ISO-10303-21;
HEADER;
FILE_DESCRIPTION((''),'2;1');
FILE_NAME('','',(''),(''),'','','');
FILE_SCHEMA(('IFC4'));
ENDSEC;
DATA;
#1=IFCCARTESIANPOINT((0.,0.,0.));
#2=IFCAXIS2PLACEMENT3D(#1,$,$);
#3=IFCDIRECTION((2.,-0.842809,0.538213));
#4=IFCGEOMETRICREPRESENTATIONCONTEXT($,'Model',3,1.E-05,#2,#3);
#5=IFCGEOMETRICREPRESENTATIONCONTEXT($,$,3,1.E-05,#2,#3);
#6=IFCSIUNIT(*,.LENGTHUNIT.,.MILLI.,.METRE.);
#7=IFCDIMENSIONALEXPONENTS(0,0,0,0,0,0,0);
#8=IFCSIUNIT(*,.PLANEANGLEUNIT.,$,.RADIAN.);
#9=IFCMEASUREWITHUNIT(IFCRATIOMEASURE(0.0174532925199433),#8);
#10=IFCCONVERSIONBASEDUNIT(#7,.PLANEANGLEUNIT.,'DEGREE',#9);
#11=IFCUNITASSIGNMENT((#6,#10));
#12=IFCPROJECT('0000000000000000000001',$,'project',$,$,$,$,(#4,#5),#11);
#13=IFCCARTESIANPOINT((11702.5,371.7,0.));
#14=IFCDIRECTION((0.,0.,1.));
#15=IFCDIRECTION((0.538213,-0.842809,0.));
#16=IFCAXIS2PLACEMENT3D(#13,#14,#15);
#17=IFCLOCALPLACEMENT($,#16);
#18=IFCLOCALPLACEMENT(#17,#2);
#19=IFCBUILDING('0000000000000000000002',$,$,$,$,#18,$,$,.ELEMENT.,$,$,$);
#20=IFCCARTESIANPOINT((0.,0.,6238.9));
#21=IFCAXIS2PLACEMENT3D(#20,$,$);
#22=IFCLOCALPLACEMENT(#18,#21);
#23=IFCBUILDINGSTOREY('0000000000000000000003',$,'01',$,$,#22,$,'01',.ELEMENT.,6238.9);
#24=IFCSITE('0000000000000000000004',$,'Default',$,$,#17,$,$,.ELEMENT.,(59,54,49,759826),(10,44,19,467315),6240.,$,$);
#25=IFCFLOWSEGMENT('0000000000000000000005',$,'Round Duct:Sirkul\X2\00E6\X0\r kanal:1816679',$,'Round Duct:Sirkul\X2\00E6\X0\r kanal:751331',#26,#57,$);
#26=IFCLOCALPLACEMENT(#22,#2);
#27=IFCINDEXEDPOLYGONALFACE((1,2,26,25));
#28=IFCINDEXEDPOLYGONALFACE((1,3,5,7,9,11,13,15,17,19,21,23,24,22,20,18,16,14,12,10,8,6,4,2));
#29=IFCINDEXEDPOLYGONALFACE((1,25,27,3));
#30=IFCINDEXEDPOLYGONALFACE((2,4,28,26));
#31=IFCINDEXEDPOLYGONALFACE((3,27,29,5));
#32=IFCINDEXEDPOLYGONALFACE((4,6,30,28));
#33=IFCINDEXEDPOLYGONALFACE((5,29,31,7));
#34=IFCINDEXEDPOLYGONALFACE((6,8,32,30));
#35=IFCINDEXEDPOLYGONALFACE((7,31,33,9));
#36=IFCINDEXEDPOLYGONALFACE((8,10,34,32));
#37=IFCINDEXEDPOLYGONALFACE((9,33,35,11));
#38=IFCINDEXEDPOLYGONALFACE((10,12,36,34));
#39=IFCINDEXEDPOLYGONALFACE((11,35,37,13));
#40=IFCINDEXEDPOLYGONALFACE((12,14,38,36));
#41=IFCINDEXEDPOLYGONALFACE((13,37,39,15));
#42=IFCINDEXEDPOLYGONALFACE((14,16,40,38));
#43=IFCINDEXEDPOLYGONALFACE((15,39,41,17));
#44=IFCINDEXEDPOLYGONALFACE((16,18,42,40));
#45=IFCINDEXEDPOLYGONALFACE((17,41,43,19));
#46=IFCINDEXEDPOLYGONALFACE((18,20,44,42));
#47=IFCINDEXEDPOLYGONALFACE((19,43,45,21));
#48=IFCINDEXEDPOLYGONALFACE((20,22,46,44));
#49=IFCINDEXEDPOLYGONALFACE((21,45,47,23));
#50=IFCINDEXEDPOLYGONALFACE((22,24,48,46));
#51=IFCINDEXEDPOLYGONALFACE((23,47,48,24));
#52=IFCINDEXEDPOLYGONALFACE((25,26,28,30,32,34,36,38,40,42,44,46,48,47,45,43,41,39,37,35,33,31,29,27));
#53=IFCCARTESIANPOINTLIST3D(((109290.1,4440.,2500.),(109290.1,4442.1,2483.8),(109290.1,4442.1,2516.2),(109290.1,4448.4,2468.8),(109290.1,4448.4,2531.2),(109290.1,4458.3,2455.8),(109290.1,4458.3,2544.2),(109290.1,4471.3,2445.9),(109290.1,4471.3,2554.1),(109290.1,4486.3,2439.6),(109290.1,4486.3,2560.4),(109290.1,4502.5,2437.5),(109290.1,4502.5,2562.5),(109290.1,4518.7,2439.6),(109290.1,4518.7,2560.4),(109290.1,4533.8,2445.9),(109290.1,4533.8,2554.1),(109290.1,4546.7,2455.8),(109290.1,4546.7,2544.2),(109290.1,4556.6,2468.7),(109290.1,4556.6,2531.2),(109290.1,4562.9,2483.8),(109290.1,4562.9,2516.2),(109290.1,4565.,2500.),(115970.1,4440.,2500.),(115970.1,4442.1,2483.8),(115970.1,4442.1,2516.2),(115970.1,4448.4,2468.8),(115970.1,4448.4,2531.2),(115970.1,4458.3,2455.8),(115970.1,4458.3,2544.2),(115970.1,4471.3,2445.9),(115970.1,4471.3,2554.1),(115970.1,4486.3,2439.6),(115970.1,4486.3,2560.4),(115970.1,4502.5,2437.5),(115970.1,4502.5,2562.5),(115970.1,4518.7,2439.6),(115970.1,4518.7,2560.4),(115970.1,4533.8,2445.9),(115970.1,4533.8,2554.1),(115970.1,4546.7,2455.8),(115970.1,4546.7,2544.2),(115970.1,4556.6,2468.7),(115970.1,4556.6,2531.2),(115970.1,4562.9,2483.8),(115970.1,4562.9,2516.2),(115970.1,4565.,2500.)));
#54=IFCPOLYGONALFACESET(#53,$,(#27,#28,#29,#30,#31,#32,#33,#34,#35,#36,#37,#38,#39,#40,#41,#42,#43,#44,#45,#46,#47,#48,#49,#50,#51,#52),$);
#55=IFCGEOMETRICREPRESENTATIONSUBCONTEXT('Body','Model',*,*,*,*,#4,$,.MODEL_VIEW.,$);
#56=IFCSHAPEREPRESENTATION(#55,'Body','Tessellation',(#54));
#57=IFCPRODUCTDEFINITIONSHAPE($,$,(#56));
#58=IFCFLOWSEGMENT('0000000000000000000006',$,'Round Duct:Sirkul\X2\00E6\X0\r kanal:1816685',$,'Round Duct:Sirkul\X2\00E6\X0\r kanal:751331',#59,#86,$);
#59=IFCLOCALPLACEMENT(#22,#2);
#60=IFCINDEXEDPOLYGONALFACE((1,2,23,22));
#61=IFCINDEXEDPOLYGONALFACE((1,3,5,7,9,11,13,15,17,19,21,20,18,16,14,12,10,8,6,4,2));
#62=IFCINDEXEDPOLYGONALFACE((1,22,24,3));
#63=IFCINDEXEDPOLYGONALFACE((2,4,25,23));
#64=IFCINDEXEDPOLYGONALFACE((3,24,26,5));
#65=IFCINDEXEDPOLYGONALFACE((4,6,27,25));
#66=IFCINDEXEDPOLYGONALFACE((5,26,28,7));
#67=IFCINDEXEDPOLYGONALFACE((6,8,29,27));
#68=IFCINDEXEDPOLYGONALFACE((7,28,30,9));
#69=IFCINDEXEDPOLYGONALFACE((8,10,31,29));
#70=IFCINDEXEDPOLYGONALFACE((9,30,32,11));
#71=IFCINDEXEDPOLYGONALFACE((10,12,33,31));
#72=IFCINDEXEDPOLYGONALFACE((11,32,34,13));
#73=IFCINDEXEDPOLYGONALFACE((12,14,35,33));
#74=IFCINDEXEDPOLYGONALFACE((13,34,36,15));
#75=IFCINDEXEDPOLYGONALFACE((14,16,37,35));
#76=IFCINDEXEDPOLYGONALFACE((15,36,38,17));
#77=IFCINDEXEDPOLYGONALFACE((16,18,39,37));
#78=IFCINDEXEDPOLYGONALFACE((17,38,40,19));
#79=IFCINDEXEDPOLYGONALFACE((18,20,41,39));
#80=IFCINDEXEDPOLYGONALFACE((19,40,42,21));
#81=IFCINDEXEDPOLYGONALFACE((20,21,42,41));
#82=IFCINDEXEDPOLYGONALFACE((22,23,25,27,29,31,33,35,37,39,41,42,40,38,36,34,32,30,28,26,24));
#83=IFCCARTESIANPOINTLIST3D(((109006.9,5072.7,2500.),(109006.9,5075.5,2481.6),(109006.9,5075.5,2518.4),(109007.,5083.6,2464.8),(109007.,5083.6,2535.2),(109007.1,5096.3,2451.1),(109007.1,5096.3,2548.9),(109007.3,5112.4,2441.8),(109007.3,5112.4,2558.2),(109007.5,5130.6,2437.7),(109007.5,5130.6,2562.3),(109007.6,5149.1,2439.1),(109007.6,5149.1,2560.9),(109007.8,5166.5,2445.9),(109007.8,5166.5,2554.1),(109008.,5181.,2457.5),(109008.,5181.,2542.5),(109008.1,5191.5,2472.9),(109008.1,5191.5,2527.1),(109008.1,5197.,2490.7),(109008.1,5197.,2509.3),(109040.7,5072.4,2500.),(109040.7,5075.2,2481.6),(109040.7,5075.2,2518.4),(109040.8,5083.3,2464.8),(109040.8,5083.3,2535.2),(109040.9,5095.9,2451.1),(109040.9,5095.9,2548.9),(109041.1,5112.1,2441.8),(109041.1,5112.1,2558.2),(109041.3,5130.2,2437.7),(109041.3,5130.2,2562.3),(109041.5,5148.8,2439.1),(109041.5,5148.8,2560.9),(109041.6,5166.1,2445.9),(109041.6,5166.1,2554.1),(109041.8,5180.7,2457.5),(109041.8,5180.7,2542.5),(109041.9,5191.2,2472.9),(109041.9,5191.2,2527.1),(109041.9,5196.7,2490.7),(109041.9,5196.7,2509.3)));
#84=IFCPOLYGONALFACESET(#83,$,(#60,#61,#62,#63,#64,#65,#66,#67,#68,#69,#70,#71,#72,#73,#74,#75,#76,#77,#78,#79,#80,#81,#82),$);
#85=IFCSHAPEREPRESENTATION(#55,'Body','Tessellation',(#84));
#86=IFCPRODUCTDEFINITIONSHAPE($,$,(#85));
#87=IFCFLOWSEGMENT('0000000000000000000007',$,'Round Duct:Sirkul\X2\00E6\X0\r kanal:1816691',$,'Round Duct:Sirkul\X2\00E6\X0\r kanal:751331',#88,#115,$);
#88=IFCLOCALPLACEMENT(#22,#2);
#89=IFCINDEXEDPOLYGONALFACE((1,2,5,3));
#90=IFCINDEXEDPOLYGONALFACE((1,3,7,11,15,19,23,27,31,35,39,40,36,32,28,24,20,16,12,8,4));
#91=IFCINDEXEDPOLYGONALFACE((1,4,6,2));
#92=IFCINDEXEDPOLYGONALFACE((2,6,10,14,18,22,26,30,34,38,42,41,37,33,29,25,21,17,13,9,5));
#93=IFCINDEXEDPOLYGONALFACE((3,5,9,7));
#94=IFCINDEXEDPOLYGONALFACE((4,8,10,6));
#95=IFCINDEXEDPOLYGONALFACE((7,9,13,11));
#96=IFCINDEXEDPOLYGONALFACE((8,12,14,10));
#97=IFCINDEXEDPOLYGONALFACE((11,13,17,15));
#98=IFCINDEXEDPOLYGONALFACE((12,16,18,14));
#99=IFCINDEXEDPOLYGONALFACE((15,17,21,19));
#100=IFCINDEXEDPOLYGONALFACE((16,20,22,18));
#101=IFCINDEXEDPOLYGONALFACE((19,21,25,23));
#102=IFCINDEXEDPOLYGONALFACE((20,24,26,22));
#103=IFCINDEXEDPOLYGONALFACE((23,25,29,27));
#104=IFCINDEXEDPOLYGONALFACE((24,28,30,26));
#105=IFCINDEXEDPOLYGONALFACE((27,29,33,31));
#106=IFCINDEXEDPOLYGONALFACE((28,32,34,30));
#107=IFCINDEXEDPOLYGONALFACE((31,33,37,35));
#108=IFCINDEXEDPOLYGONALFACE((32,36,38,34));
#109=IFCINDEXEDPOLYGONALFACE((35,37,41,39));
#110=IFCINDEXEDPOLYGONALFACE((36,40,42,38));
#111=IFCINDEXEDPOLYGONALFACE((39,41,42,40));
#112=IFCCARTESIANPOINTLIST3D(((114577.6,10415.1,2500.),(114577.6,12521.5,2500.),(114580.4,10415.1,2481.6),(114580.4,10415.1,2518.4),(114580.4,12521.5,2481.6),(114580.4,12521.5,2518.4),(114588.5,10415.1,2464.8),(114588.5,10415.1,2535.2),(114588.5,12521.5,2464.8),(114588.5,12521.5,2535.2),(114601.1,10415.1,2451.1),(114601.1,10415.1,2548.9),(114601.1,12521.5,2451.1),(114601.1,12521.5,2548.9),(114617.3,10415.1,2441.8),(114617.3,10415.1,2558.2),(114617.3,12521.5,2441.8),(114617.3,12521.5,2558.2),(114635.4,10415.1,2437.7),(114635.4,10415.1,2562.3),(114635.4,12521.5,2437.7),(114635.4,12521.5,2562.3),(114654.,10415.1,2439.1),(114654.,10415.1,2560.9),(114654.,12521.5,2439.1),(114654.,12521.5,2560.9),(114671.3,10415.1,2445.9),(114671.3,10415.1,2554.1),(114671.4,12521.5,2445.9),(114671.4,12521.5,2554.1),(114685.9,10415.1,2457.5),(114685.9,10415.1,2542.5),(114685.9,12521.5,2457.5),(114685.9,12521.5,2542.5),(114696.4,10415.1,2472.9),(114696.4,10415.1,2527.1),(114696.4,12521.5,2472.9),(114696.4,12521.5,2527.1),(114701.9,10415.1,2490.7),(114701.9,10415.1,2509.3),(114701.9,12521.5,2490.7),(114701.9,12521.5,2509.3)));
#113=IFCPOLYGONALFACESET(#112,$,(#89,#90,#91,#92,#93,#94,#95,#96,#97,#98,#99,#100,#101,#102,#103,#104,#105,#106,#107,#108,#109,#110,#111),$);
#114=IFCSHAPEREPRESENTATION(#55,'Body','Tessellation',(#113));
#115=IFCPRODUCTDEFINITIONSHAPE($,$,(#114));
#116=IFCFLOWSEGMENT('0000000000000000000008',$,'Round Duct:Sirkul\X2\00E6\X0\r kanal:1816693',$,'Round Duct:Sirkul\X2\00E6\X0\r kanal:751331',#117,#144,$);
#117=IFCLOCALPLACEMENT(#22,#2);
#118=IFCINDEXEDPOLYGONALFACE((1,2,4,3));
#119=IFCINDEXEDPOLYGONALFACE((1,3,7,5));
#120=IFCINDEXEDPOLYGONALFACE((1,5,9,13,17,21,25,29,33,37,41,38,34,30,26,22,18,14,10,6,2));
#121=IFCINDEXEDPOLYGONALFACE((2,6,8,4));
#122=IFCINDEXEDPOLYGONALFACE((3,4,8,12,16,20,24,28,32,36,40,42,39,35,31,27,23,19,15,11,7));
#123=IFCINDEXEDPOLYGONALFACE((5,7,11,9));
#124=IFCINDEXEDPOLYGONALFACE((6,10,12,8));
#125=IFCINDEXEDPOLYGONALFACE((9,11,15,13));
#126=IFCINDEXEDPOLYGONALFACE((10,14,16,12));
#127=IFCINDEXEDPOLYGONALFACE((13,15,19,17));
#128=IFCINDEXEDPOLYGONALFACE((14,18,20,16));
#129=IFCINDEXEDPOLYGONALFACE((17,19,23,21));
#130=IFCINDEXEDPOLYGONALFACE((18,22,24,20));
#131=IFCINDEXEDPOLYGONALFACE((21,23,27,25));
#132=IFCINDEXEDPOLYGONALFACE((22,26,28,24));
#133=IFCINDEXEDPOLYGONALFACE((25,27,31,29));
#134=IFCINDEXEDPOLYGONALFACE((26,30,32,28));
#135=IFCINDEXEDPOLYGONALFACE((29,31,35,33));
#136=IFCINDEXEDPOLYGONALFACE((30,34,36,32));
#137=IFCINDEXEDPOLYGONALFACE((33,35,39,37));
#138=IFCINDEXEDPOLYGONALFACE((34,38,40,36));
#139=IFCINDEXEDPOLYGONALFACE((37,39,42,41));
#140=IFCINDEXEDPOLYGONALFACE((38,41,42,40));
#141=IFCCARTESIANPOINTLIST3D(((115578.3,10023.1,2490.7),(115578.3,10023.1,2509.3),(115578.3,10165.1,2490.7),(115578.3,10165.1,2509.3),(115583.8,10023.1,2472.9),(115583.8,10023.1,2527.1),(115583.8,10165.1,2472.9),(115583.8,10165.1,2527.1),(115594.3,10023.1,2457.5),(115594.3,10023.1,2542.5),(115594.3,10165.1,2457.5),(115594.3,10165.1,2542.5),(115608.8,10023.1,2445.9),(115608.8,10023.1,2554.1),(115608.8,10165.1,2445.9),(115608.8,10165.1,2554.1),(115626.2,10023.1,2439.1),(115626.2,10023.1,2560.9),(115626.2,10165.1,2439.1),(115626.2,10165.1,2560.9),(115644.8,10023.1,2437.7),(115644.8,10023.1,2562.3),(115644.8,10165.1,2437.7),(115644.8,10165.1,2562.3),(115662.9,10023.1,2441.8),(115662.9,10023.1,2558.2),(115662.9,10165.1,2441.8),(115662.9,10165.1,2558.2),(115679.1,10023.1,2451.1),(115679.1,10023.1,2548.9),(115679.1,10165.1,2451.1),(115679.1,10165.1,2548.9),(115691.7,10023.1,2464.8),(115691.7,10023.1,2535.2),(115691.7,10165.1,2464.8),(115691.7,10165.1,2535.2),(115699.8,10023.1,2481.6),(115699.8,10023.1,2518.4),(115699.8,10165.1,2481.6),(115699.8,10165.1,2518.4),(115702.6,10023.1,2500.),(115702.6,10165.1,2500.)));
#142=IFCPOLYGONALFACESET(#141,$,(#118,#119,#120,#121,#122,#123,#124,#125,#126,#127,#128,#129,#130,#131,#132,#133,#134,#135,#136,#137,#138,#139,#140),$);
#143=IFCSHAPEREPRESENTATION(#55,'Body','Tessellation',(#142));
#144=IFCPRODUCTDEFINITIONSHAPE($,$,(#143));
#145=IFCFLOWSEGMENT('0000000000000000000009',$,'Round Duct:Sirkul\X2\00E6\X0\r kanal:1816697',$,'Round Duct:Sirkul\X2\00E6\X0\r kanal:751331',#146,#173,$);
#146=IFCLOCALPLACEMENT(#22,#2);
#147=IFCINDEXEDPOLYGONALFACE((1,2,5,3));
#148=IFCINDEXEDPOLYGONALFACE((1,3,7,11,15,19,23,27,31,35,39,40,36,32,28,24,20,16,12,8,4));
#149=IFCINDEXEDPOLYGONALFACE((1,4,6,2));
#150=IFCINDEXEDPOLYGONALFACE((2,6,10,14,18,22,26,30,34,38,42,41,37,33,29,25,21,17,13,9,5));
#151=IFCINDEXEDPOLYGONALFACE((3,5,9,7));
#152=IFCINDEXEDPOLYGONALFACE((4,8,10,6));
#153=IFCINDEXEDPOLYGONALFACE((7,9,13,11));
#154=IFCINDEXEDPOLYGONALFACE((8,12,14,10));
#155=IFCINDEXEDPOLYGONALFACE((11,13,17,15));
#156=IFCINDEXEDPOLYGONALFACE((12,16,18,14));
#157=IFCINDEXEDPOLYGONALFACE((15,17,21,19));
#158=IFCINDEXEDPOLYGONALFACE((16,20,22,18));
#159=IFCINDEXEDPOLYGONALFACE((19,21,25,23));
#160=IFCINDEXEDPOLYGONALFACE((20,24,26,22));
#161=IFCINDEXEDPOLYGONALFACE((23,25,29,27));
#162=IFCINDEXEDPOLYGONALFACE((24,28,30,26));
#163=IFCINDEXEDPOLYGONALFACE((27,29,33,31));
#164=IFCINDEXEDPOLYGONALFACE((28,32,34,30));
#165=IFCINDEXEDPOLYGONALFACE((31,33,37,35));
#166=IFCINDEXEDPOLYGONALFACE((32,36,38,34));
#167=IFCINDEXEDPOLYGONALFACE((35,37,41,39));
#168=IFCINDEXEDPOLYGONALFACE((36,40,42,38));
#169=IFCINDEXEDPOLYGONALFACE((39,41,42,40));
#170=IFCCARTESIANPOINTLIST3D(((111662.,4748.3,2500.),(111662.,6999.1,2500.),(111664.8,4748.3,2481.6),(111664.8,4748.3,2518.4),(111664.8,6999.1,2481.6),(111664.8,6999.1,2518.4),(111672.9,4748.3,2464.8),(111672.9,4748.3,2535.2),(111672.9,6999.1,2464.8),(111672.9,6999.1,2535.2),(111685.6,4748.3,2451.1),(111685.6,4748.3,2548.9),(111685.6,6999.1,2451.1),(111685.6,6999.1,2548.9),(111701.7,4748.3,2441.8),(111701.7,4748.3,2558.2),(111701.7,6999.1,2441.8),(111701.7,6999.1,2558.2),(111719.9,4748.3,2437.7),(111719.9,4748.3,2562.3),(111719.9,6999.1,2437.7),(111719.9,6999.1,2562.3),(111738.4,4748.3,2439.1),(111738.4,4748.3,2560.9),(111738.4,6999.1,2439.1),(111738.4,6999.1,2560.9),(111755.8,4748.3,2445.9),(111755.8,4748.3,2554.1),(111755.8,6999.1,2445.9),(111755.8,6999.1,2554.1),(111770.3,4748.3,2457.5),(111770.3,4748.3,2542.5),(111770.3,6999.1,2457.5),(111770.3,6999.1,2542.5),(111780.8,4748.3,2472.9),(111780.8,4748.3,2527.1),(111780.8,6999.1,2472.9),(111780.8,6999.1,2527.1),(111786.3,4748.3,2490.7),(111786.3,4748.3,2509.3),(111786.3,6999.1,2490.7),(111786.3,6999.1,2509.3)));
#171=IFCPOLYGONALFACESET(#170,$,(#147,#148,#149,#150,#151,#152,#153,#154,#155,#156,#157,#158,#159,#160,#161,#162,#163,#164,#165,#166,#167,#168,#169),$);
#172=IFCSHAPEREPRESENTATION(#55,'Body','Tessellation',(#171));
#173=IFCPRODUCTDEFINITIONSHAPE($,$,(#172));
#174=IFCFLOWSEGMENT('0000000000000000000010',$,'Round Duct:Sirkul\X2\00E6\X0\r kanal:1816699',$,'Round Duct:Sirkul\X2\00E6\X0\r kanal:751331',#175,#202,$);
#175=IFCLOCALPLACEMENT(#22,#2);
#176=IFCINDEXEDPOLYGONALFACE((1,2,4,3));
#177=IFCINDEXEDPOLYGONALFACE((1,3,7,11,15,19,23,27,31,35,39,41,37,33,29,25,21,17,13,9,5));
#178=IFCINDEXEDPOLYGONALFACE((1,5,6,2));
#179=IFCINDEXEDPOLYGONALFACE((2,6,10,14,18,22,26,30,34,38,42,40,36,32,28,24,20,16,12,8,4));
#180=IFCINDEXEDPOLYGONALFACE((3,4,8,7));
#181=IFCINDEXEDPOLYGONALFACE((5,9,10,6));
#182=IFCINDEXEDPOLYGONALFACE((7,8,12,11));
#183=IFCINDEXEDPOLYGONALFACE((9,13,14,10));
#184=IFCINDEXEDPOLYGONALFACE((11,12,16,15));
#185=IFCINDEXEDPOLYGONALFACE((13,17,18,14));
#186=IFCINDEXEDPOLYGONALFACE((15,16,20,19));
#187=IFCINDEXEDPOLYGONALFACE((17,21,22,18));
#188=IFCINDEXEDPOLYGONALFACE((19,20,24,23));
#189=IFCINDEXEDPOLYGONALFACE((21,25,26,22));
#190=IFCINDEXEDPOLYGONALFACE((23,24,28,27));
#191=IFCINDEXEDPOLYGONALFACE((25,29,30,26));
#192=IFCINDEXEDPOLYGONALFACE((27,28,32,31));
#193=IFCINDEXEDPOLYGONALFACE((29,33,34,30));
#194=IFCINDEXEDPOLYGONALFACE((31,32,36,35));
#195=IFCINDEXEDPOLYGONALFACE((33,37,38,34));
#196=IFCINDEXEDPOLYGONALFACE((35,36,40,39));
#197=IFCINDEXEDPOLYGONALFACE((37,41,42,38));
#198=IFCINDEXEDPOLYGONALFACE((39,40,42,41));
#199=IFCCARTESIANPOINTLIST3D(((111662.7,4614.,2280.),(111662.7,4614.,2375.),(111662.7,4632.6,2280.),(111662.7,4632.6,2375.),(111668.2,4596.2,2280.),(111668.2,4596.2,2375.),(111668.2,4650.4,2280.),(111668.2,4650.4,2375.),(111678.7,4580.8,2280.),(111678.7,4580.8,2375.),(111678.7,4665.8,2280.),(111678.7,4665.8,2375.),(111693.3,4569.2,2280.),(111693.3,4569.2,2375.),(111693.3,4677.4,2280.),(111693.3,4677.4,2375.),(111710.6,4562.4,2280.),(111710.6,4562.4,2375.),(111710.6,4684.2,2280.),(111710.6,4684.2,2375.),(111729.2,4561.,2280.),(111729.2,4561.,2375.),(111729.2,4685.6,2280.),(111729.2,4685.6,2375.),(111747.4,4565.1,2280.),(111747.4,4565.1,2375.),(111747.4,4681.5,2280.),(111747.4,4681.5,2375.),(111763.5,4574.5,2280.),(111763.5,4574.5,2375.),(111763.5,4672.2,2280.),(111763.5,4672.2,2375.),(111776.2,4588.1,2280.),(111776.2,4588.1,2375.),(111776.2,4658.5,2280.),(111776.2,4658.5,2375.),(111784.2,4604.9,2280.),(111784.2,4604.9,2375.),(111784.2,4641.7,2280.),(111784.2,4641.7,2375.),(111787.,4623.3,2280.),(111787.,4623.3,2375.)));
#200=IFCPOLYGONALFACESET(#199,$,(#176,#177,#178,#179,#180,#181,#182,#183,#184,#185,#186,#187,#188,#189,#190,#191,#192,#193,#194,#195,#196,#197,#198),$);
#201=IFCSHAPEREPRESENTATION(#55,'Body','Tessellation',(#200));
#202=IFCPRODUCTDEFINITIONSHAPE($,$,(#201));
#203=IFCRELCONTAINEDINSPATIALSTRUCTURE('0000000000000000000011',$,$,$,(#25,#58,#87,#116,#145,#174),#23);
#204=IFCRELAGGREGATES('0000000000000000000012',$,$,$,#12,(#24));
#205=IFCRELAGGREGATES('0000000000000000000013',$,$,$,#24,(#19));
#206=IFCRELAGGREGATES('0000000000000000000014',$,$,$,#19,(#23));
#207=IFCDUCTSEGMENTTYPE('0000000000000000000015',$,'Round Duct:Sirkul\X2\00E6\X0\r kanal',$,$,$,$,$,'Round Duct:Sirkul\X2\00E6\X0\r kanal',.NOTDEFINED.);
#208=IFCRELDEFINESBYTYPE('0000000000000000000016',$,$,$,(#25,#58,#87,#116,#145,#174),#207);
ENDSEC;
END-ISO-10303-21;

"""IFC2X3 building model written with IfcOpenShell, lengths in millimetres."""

from ifc_helpers import new_model, entity, si_unit, converted_unit, direction, frame, frame_2d, origin, origin_2d_with_axis, place, context, subcontext, project, spatial, polyline, circle, outline, extrude, type_object, element, save


model = new_model("IFC2X3")

# Units and contexts
model_context = context("Model", 3, precision=1e-05, world=origin(), true_north=direction((2.0, -0.842809, 0.538213)))
context_of_model = context(None, 3, precision=1e-05, world=origin(), true_north=direction((2.0, -0.842809, 0.538213)))
body_context = subcontext(model_context, "Body", "Model", "MODEL_VIEW")
ifc_project = project(units=[si_unit("LENGTHUNIT", "METRE", prefix="MILLI"), converted_unit("PLANEANGLEUNIT", "DEGREE", entity("IfcRatioMeasure", 0.0174532925199433), si_unit("PLANEANGLEUNIT", "RADIAN"), dimensions=[0, 0, 0, 0, 0, 0, 0])], contexts=[model_context, context_of_model])

# Site, building, storey
site_placement = place(None, frame((11702.5, 371.7, 0.0), z_axis=(0.0, 0.0, 1.0), x_axis=(0.538213, -0.842809, 0.0)))
site = spatial("IfcSite", under=ifc_project, at=site_placement, Name="Default", CompositionType="ELEMENT", RefLatitude=(59, 54, 49, 759826), RefLongitude=(10, 44, 19, 467315), RefElevation=6240.0)
building_placement = place(site_placement, origin())
building = spatial("IfcBuilding", under=site, at=building_placement, CompositionType="ELEMENT")
storey_placement = place(building_placement, frame((0.0, 0.0, 6238.9)))
storey = spatial("IfcBuildingStorey", under=building, at=storey_placement, Name="01", LongName="01", CompositionType="ELEMENT", Elevation=6238.9)

# Flow segments
duct_segment_type = type_object("IfcDuctSegmentType", Name="Round Duct:Sirkulær kanal", ElementType="Round Duct:Sirkulær kanal", PredefinedType="NOTDEFINED")
flow_segment_1_placement = place(storey_placement, origin())
element("IfcFlowSegment", 1, at=flow_segment_1_placement, inside=storey, type_object=duct_segment_type, Name="Round Duct:Sirkulær kanal:1816679", ObjectType="Round Duct:Sirkulær kanal:751331", context=body_context, shape_type="SweptSolid", body=[
    extrude(outline(polyline([(-8.2, -62.0), (8.2, -62.0), (23.9, -57.7), (38.0, -49.6), (49.6, -38.0), (57.7, -23.9), (62.0, -8.2), (62.0, 8.2), (57.7, 23.9), (49.6, 38.0), (38.0, 49.6), (23.9, 57.7), (8.2, 62.0), (-8.2, 62.0), (-23.9, 57.7), (-38.0, 49.6), (-49.6, 38.0), (-57.7, 23.9), (-62.0, 8.2), (-62.0, -8.2), (-57.7, -23.9), (-49.6, -38.0), (-38.0, -49.6), (-23.9, -57.7), (-8.2, -62.0)])), frame((109290.1, 4502.5, 2500.0), z_axis=(1.0, 0.0, 0.0), x_axis=(0.0, -0.130526, 0.991445)), (0.0, 0.0, 1.0), 6680.0),
])
flow_segment_2_placement = place(storey_placement, origin())
element("IfcFlowSegment", 2, at=flow_segment_2_placement, inside=storey, type_object=duct_segment_type, Name="Round Duct:Sirkulær kanal:1816685", ObjectType="Round Duct:Sirkulær kanal:751331", context=body_context, shape_type="SweptSolid", body=[
    extrude(circle(Radius=62.5, at=origin_2d_with_axis()), frame((109041.3, 5134.9, 2500.0), z_axis=(-0.999952, 0.00981, 0.0), x_axis=(-0.00981, -0.999952, 0.0)), (0.0, 0.0, 1.0), 33.8),
])
flow_segment_3_placement = place(storey_placement, origin())
element("IfcFlowSegment", 3, at=flow_segment_3_placement, inside=storey, type_object=duct_segment_type, Name="Round Duct:Sirkulær kanal:1816691", ObjectType="Round Duct:Sirkulær kanal:751331", context=body_context, shape_type="SweptSolid", body=[
    extrude(circle(Radius=62.5, at=frame_2d((0.0, 0.0), x_axis=(1.0, 0.0))), frame((114640.1, 10415.1, 2500.0), z_axis=(0.000003, 1.0, 0.0), x_axis=(-1.0, 0.000003, 0.0)), (0.0, 0.0, 1.0), 2106.4),
])
flow_segment_4_placement = place(storey_placement, origin())
element("IfcFlowSegment", 4, at=flow_segment_4_placement, inside=storey, type_object=duct_segment_type, Name="Round Duct:Sirkulær kanal:1816693", ObjectType="Round Duct:Sirkulær kanal:751331", context=body_context, shape_type="SweptSolid", body=[
    extrude(circle(Radius=62.5, at=frame_2d((0.0, 0.0), x_axis=(1.0, 0.0))), frame((115640.1, 10023.1, 2500.0), z_axis=(0.000027, 1.0, 0.0), x_axis=(1.0, -0.000027, 0.0)), (0.0, 0.0, 1.0), 142.0),
])
flow_segment_5_placement = place(storey_placement, origin())
element("IfcFlowSegment", 5, at=flow_segment_5_placement, inside=storey, type_object=duct_segment_type, Name="Round Duct:Sirkulær kanal:1816697", ObjectType="Round Duct:Sirkulær kanal:751331", context=body_context, shape_type="SweptSolid", body=[
    extrude(circle(Radius=62.5, at=origin_2d_with_axis()), frame((111724.5, 4748.3, 2500.0), z_axis=(0.000001, 1.0, 0.0), x_axis=(-1.0, 0.000001, 0.0)), (0.0, 0.0, 1.0), 2250.8),
])
flow_segment_6_placement = place(storey_placement, origin())
element("IfcFlowSegment", 6, at=flow_segment_6_placement, inside=storey, type_object=duct_segment_type, Name="Round Duct:Sirkulær kanal:1816699", ObjectType="Round Duct:Sirkulær kanal:751331", context=body_context, shape_type="SweptSolid", body=[
    extrude(circle(Radius=62.5, at=origin_2d_with_axis()), frame((111724.5, 4623.3, 2280.0)), (0.0, 0.0, 1.0), 95.0),
])

save(model, "model.ifc")
